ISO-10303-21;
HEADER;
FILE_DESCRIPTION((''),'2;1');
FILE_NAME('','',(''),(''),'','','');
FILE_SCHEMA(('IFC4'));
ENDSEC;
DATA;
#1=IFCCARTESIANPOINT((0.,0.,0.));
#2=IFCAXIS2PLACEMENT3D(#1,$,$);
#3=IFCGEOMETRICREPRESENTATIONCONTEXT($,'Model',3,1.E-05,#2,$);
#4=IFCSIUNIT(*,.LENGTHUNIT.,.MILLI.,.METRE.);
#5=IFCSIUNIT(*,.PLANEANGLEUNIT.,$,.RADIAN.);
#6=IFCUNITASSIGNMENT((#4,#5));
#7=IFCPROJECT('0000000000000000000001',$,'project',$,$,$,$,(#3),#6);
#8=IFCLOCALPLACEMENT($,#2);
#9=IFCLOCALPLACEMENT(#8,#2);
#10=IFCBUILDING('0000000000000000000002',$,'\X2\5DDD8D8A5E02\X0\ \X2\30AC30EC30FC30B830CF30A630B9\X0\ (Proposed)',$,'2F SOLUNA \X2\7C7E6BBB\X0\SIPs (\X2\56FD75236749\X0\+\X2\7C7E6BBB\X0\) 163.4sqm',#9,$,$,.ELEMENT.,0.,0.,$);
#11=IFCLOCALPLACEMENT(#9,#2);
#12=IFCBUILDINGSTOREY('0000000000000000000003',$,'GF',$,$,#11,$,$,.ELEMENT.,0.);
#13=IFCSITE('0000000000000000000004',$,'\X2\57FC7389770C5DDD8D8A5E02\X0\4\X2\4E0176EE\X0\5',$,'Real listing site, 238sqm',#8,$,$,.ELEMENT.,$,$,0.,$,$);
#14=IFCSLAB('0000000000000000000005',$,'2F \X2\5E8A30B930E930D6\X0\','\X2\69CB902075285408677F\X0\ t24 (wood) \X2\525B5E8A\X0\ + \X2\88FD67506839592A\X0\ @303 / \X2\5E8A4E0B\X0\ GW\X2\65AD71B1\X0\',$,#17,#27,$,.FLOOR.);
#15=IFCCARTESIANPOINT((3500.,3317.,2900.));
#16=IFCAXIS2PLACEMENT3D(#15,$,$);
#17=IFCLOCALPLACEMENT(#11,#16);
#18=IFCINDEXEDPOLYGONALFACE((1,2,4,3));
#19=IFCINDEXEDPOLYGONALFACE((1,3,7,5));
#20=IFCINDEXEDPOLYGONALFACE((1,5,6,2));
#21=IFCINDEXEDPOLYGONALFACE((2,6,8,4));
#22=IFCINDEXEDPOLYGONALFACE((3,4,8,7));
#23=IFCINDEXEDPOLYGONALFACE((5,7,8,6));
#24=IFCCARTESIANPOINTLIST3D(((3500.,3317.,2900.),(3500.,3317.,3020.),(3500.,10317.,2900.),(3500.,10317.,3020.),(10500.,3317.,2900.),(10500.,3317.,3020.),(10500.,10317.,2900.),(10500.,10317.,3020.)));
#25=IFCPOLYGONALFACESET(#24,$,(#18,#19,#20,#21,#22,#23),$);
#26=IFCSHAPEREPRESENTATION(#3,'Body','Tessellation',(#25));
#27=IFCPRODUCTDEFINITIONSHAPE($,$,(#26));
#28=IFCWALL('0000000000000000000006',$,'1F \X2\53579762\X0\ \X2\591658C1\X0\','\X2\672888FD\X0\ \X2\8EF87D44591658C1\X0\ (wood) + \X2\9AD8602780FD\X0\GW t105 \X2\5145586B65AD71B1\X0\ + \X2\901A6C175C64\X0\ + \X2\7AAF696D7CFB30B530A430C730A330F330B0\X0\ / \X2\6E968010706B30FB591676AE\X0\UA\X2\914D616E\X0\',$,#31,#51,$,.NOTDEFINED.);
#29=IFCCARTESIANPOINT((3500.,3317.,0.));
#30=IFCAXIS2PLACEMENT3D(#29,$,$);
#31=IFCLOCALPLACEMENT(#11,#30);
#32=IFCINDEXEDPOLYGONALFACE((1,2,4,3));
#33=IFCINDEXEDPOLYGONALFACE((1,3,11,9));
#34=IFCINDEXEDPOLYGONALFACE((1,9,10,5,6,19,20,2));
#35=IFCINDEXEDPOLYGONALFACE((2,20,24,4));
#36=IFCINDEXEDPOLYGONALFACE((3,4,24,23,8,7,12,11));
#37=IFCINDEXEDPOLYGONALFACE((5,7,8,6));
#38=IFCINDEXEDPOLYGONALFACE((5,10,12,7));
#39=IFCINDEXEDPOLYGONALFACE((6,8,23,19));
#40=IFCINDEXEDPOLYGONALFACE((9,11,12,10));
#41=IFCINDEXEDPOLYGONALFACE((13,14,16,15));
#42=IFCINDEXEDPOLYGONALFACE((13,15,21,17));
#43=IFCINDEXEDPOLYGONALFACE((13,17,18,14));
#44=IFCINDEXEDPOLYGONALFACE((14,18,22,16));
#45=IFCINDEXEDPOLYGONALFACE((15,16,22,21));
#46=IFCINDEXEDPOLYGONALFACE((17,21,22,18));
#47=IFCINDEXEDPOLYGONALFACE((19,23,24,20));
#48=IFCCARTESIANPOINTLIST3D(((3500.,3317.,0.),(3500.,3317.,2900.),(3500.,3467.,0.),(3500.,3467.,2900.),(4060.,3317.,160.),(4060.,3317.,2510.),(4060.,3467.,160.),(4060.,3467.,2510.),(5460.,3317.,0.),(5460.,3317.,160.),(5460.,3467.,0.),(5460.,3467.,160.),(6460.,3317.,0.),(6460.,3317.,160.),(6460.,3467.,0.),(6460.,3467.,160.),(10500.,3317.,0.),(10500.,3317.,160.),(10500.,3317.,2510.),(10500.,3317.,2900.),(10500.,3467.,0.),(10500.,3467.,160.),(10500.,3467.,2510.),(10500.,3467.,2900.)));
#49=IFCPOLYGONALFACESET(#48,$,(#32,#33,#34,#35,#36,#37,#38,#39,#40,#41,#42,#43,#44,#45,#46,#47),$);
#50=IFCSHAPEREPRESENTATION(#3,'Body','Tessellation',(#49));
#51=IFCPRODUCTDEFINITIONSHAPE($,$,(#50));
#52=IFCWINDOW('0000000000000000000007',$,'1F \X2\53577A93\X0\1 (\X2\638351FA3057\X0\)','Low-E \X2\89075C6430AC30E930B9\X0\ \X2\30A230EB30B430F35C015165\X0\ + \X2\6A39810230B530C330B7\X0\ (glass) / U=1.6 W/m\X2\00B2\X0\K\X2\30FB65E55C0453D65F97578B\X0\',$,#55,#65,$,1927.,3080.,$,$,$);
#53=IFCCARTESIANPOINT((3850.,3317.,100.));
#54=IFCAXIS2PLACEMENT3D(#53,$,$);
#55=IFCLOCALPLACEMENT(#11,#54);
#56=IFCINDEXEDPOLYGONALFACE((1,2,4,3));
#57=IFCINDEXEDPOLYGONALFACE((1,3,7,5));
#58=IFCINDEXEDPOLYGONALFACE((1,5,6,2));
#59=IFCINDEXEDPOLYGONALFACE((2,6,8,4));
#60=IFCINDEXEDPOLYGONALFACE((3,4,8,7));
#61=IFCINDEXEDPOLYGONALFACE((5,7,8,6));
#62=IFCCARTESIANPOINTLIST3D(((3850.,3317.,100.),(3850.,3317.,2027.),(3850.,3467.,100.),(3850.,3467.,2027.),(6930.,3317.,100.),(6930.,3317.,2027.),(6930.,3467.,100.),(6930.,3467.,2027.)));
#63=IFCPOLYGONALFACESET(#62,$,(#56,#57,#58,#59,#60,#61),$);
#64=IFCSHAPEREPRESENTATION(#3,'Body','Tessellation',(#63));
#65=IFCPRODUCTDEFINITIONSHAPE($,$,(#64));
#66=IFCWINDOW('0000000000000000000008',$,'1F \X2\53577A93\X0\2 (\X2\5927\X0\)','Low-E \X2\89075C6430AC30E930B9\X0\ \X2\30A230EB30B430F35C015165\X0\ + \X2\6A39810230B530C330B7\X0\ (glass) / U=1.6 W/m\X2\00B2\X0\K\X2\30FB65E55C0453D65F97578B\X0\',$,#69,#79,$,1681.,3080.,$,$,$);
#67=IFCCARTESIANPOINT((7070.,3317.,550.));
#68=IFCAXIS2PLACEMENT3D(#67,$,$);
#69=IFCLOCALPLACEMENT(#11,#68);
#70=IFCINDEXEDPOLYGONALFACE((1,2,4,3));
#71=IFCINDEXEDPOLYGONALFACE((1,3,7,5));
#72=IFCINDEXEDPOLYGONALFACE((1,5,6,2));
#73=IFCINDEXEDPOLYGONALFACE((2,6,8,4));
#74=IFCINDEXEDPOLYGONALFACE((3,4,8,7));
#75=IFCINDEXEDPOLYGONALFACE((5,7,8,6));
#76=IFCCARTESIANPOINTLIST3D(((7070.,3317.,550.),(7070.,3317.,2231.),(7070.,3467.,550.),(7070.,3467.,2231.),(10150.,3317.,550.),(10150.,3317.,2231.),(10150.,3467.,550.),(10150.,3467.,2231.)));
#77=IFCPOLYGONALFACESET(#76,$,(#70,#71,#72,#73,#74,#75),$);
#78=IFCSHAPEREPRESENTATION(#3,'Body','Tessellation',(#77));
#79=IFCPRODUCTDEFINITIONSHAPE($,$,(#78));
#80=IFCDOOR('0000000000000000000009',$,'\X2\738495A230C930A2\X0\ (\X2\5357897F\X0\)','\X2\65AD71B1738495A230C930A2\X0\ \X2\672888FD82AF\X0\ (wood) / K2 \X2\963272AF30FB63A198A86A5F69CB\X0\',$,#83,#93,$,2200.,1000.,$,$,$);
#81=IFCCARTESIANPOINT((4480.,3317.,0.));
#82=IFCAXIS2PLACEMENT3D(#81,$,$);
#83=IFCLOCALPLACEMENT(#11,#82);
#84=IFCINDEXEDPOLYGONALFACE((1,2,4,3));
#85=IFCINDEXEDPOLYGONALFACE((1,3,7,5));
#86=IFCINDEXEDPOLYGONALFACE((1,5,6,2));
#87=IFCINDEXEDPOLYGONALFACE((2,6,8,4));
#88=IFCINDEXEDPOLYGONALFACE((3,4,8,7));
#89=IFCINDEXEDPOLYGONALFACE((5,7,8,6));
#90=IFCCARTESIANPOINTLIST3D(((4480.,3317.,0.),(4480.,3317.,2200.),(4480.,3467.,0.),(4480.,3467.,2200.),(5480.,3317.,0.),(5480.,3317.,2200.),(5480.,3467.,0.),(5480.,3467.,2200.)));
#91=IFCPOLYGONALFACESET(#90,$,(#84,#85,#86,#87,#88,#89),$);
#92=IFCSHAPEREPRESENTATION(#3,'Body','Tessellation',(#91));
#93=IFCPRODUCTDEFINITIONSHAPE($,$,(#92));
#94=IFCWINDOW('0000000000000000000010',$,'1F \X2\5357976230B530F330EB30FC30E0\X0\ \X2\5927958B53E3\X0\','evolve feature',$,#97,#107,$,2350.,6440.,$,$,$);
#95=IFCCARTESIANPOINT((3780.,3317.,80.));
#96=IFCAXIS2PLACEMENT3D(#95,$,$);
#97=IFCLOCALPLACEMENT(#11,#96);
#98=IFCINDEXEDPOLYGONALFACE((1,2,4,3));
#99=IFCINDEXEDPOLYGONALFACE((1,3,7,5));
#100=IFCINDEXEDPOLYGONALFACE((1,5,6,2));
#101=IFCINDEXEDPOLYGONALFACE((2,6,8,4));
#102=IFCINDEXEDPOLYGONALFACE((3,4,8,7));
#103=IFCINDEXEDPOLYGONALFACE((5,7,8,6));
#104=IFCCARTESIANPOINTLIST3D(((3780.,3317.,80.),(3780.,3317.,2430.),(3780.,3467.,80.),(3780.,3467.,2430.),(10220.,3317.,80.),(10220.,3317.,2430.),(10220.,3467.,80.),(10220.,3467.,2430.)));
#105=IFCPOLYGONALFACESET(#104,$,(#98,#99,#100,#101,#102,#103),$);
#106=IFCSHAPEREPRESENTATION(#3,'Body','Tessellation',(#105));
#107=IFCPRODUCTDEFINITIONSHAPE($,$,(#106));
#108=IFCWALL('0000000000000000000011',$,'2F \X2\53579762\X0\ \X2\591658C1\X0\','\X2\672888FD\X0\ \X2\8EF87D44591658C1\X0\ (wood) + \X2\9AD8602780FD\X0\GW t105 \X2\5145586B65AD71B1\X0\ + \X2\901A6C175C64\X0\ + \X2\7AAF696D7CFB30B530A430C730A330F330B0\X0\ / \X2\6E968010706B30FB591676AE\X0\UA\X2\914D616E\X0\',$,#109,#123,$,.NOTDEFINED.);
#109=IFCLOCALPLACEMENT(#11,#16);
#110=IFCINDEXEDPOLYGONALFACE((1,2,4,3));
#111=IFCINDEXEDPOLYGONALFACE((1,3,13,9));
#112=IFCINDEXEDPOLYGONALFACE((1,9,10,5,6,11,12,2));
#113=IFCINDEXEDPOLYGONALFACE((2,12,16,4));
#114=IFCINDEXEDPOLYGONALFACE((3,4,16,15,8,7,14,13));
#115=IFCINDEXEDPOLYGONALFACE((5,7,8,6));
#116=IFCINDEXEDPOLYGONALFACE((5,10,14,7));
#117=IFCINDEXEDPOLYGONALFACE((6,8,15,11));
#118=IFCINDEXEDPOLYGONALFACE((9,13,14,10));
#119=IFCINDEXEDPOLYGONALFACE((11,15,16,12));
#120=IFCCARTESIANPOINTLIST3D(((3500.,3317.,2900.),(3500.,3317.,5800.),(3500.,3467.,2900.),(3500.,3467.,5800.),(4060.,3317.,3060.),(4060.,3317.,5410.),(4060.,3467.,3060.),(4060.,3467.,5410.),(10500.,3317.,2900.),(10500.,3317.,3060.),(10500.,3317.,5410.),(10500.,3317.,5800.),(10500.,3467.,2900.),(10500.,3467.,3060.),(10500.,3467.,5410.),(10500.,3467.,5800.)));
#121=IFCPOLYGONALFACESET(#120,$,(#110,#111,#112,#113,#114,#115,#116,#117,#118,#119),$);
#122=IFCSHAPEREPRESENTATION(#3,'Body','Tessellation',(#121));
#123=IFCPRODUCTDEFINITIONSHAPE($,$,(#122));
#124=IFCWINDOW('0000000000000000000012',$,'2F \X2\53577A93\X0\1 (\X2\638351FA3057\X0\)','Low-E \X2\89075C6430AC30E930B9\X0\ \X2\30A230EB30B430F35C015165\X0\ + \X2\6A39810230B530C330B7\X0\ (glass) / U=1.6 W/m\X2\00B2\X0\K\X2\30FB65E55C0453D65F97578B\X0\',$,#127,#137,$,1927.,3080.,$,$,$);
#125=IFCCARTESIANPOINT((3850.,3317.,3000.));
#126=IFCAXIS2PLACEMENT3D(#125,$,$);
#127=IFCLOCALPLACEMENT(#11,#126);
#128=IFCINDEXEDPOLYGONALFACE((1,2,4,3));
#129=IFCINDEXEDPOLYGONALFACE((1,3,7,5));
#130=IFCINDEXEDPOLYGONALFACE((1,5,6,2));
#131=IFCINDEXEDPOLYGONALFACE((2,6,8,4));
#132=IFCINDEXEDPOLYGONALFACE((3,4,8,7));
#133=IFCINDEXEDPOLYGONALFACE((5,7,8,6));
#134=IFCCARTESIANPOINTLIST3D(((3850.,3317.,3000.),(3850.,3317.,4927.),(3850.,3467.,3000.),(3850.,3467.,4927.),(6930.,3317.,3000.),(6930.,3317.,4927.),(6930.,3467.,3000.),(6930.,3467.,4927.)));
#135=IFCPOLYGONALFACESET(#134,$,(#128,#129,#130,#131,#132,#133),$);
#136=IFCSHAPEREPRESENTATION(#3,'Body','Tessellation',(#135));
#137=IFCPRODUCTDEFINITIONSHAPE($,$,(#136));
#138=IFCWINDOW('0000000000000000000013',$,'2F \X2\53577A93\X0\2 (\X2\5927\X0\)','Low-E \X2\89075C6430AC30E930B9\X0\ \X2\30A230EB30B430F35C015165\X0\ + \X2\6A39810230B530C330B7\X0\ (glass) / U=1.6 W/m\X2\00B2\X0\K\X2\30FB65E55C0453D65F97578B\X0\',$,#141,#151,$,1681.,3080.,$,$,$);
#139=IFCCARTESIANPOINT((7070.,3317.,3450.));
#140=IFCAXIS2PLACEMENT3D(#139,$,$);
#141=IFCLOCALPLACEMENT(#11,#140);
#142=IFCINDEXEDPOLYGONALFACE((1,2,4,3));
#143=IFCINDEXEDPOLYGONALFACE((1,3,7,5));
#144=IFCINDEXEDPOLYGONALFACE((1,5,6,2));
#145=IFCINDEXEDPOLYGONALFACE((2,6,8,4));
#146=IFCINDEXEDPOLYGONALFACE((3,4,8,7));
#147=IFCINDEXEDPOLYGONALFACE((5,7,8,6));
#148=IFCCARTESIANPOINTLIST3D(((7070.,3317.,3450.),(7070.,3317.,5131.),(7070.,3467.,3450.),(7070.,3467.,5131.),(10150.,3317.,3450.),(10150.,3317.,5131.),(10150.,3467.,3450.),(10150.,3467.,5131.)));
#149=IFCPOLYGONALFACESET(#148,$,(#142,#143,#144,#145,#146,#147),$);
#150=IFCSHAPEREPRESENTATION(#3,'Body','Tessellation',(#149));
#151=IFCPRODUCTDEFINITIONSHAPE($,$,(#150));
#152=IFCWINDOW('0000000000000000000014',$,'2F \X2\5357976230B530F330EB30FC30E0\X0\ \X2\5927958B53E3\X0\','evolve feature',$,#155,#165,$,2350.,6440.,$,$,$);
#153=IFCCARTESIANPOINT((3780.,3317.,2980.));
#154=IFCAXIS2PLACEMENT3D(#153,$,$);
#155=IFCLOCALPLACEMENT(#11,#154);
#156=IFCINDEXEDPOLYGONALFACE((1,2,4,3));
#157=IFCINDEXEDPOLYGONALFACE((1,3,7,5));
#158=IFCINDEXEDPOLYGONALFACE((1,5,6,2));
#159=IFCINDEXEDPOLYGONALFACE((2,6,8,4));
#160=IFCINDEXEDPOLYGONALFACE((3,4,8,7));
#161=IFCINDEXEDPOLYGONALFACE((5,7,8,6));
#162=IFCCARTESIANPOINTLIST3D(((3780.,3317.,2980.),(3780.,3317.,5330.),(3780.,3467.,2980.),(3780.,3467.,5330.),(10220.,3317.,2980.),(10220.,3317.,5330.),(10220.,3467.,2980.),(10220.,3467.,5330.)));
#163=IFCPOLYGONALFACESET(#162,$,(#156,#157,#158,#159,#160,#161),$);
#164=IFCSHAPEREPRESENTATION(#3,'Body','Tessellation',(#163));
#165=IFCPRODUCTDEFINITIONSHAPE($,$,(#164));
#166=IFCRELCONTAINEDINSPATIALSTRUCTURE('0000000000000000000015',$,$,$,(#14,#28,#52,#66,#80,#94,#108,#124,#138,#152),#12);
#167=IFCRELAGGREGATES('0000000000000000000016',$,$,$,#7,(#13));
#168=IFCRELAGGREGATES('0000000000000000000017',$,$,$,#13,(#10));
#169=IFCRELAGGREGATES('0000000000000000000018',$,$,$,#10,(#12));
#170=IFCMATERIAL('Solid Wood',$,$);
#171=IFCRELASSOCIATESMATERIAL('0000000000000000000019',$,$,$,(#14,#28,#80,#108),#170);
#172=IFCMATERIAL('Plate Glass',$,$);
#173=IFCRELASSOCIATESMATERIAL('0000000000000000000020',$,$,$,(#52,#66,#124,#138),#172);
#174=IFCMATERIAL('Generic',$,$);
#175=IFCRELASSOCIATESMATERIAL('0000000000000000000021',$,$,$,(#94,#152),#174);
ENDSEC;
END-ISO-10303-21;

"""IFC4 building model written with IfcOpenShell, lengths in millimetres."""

from ifc_helpers import new_model, si_unit, frame, frame_2d, origin, place, context, project, spatial, rectangle, extrude, material, element, fill, save


model = new_model("IFC4")

# Units and contexts
model_context = context("Model", 3, precision=1e-05, world=origin())
ifc_project = project(units=[si_unit("LENGTHUNIT", "METRE", prefix="MILLI"), si_unit("PLANEANGLEUNIT", "RADIAN")], contexts=[model_context])

# Site, building, storey
site_placement = place(None, origin())
site = spatial("IfcSite", under=ifc_project, at=site_placement, Name="埼玉県川越市4丁目5", ObjectType="Real listing site, 238sqm", CompositionType="ELEMENT", RefElevation=0.0)
building_placement = place(site_placement, origin())
building = spatial("IfcBuilding", under=site, at=building_placement, Name="川越市 ガレージハウス (Proposed)", ObjectType="2F SOLUNA 籾殻SIPs (国産杉+籾殻) 163.4sqm", CompositionType="ELEMENT", ElevationOfRefHeight=0.0, ElevationOfTerrain=0.0)
storey_placement = place(building_placement, origin())
storey = spatial("IfcBuildingStorey", under=building, at=storey_placement, Name="GF", CompositionType="ELEMENT", Elevation=0.0)

# Slab
ifc_material_1 = material(Name="Solid Wood")
slab_1_placement = place(storey_placement, frame((3500.0, 3317.0, 2900.0)))
element("IfcSlab", 1, at=slab_1_placement, inside=storey, material=ifc_material_1, Name="2F 床スラブ", Description="構造用合板 t24 (wood) 剛床 + 製材根太 @303 / 床下 GW断熱", PredefinedType="FLOOR", context=model_context, shape_type="SweptSolid", body=[
    extrude(rectangle(XDim=7000.0, YDim=7000.0, at=frame_2d((3500.0, 3500.0))), frame((3500.0, 3317.0, 2900.0)), (0.0, 0.0, 1.0), 120.0),
])
ifc_material_2 = material(Name="Generic")

# Wall, openings, windows, door
wall_1_placement = place(storey_placement, frame((3500.0, 3317.0, 0.0)))
wall_1 = element("IfcWall", 2, at=wall_1_placement, inside=storey, material=ifc_material_1, Name="1F 南面 外壁", Description="木製 軸組外壁 (wood) + 高性能GW t105 充填断熱 + 通気層 + 窯業系サイディング / 準耐火・外皮UA配慮", PredefinedType="NOTDEFINED", context=model_context, shape_type="SweptSolid", body=[
    extrude(rectangle(XDim=7000.0, YDim=150.0, at=frame_2d((3500.0, 75.0))), frame((3500.0, 3317.0, 0.0)), (0.0, 0.0, 1.0), 2900.0),
])
opening_1_placement = place(storey_placement, frame((3850.0, 3317.0, 100.0)))
opening_1 = element("IfcOpeningElement", 3, at=opening_1_placement, cuts=wall_1, PredefinedType="NOTDEFINED", context=model_context, shape_type="SweptSolid", body=[
    extrude(rectangle(XDim=3080.0, YDim=150.0, at=frame_2d((1540.0, 75.0))), frame((3850.0, 3317.0, 100.0)), (0.0, 0.0, 1.0), 1927.0),
])
opening_2_placement = place(storey_placement, frame((7070.0, 3317.0, 550.0)))
opening_2 = element("IfcOpeningElement", 4, at=opening_2_placement, cuts=wall_1, PredefinedType="NOTDEFINED", context=model_context, shape_type="SweptSolid", body=[
    extrude(rectangle(XDim=3080.0, YDim=150.0, at=frame_2d((1540.0, 75.0))), frame((7070.0, 3317.0, 550.0)), (0.0, 0.0, 1.0), 1681.0),
])
opening_3_placement = place(storey_placement, frame((4480.0, 3317.0, 0.0)))
opening_3 = element("IfcOpeningElement", 5, at=opening_3_placement, cuts=wall_1, PredefinedType="NOTDEFINED", context=model_context, shape_type="SweptSolid", body=[
    extrude(rectangle(XDim=1000.0, YDim=150.0, at=frame_2d((500.0, 75.0))), frame((4480.0, 3317.0, 0.0)), (0.0, 0.0, 1.0), 2200.0),
])
opening_4_placement = place(storey_placement, frame((3780.0, 3317.0, 80.0)))
opening_4 = element("IfcOpeningElement", 6, at=opening_4_placement, cuts=wall_1, PredefinedType="NOTDEFINED", context=model_context, shape_type="SweptSolid", body=[
    extrude(rectangle(XDim=6440.0, YDim=150.0, at=frame_2d((3220.0, 75.0))), frame((3780.0, 3317.0, 80.0)), (0.0, 0.0, 1.0), 2350.0),
])
ifc_material_3 = material(Name="Plate Glass")
window_1_placement = place(storey_placement, frame((3850.0, 3317.0, 100.0)))
window_1 = element("IfcWindow", 7, at=window_1_placement, inside=storey, material=ifc_material_3, Name="1F 南窓1 (掃出し)", Description="Low-E 複層ガラス アルゴン封入 + 樹脂サッシ (glass) / U=1.6 W/m²K・日射取得型", OverallHeight=1927.0, OverallWidth=3080.0, context=model_context, shape_type="SweptSolid", body=[
    extrude(rectangle(XDim=3080.0, YDim=150.0, at=frame_2d((1540.0, 75.0))), frame((3850.0, 3317.0, 100.0)), (0.0, 0.0, 1.0), 1927.0),
])
fill(opening_1, window_1)
window_2_placement = place(storey_placement, frame((7070.0, 3317.0, 550.0)))
window_2 = element("IfcWindow", 8, at=window_2_placement, inside=storey, material=ifc_material_3, Name="1F 南窓2 (大)", Description="Low-E 複層ガラス アルゴン封入 + 樹脂サッシ (glass) / U=1.6 W/m²K・日射取得型", OverallHeight=1681.0, OverallWidth=3080.0, context=model_context, shape_type="SweptSolid", body=[
    extrude(rectangle(XDim=3080.0, YDim=150.0, at=frame_2d((1540.0, 75.0))), frame((7070.0, 3317.0, 550.0)), (0.0, 0.0, 1.0), 1681.0),
])
fill(opening_2, window_2)
door_placement = place(storey_placement, frame((4480.0, 3317.0, 0.0)))
door = element("IfcDoor", 9, at=door_placement, inside=storey, material=ifc_material_1, Name="玄関ドア (南西)", Description="断熱玄関ドア 木製芯 (wood) / K2 防犯・採風機構", OverallHeight=2200.0, OverallWidth=1000.0, context=model_context, shape_type="SweptSolid", body=[
    extrude(rectangle(XDim=1000.0, YDim=150.0, at=frame_2d((500.0, 75.0))), frame((4480.0, 3317.0, 0.0)), (0.0, 0.0, 1.0), 2200.0),
])
fill(opening_3, door)
window_3_placement = place(storey_placement, frame((3780.0, 3317.0, 80.0)))
window_3 = element("IfcWindow", 10, at=window_3_placement, inside=storey, material=ifc_material_2, Name="1F 南面サンルーム 大開口", Description="evolve feature", OverallHeight=2350.0, OverallWidth=6440.0, context=model_context, shape_type="SweptSolid", body=[
    extrude(rectangle(XDim=6440.0, YDim=150.0, at=frame_2d((3220.0, 75.0))), frame((3780.0, 3317.0, 80.0)), (0.0, 0.0, 1.0), 2350.0),
])
fill(opening_4, window_3)

# Wall, openings, windows
wall_2_placement = place(storey_placement, frame((3500.0, 3317.0, 2900.0)))
wall_2 = element("IfcWall", 11, at=wall_2_placement, inside=storey, material=ifc_material_1, Name="2F 南面 外壁", Description="木製 軸組外壁 (wood) + 高性能GW t105 充填断熱 + 通気層 + 窯業系サイディング / 準耐火・外皮UA配慮", PredefinedType="NOTDEFINED", context=model_context, shape_type="SweptSolid", body=[
    extrude(rectangle(XDim=7000.0, YDim=150.0, at=frame_2d((3500.0, 75.0))), frame((3500.0, 3317.0, 2900.0)), (0.0, 0.0, 1.0), 2900.0),
])
opening_5_placement = place(storey_placement, frame((3850.0, 3317.0, 3000.0)))
opening_5 = element("IfcOpeningElement", 12, at=opening_5_placement, cuts=wall_2, PredefinedType="NOTDEFINED", context=model_context, shape_type="SweptSolid", body=[
    extrude(rectangle(XDim=3080.0, YDim=150.0, at=frame_2d((1540.0, 75.0))), frame((3850.0, 3317.0, 3000.0)), (0.0, 0.0, 1.0), 1927.0),
])
opening_6_placement = place(storey_placement, frame((7070.0, 3317.0, 3450.0)))
opening_6 = element("IfcOpeningElement", 13, at=opening_6_placement, cuts=wall_2, PredefinedType="NOTDEFINED", context=model_context, shape_type="SweptSolid", body=[
    extrude(rectangle(XDim=3080.0, YDim=150.0, at=frame_2d((1540.0, 75.0))), frame((7070.0, 3317.0, 3450.0)), (0.0, 0.0, 1.0), 1681.0),
])
opening_7_placement = place(storey_placement, frame((3780.0, 3317.0, 2980.0)))
opening_7 = element("IfcOpeningElement", 14, at=opening_7_placement, cuts=wall_2, PredefinedType="NOTDEFINED", context=model_context, shape_type="SweptSolid", body=[
    extrude(rectangle(XDim=6440.0, YDim=150.0, at=frame_2d((3220.0, 75.0))), frame((3780.0, 3317.0, 2980.0)), (0.0, 0.0, 1.0), 2350.0),
])
window_4_placement = place(storey_placement, frame((3850.0, 3317.0, 3000.0)))
window_4 = element("IfcWindow", 15, at=window_4_placement, inside=storey, material=ifc_material_3, Name="2F 南窓1 (掃出し)", Description="Low-E 複層ガラス アルゴン封入 + 樹脂サッシ (glass) / U=1.6 W/m²K・日射取得型", OverallHeight=1927.0, OverallWidth=3080.0, context=model_context, shape_type="SweptSolid", body=[
    extrude(rectangle(XDim=3080.0, YDim=150.0, at=frame_2d((1540.0, 75.0))), frame((3850.0, 3317.0, 3000.0)), (0.0, 0.0, 1.0), 1927.0),
])
fill(opening_5, window_4)
window_5_placement = place(storey_placement, frame((7070.0, 3317.0, 3450.0)))
window_5 = element("IfcWindow", 16, at=window_5_placement, inside=storey, material=ifc_material_3, Name="2F 南窓2 (大)", Description="Low-E 複層ガラス アルゴン封入 + 樹脂サッシ (glass) / U=1.6 W/m²K・日射取得型", OverallHeight=1681.0, OverallWidth=3080.0, context=model_context, shape_type="SweptSolid", body=[
    extrude(rectangle(XDim=3080.0, YDim=150.0, at=frame_2d((1540.0, 75.0))), frame((7070.0, 3317.0, 3450.0)), (0.0, 0.0, 1.0), 1681.0),
])
fill(opening_6, window_5)
window_6_placement = place(storey_placement, frame((3780.0, 3317.0, 2980.0)))
window_6 = element("IfcWindow", 17, at=window_6_placement, inside=storey, material=ifc_material_2, Name="2F 南面サンルーム 大開口", Description="evolve feature", OverallHeight=2350.0, OverallWidth=6440.0, context=model_context, shape_type="SweptSolid", body=[
    extrude(rectangle(XDim=6440.0, YDim=150.0, at=frame_2d((3220.0, 75.0))), frame((3780.0, 3317.0, 2980.0)), (0.0, 0.0, 1.0), 2350.0),
])
fill(opening_7, window_6)

save(model, "model.ifc")
